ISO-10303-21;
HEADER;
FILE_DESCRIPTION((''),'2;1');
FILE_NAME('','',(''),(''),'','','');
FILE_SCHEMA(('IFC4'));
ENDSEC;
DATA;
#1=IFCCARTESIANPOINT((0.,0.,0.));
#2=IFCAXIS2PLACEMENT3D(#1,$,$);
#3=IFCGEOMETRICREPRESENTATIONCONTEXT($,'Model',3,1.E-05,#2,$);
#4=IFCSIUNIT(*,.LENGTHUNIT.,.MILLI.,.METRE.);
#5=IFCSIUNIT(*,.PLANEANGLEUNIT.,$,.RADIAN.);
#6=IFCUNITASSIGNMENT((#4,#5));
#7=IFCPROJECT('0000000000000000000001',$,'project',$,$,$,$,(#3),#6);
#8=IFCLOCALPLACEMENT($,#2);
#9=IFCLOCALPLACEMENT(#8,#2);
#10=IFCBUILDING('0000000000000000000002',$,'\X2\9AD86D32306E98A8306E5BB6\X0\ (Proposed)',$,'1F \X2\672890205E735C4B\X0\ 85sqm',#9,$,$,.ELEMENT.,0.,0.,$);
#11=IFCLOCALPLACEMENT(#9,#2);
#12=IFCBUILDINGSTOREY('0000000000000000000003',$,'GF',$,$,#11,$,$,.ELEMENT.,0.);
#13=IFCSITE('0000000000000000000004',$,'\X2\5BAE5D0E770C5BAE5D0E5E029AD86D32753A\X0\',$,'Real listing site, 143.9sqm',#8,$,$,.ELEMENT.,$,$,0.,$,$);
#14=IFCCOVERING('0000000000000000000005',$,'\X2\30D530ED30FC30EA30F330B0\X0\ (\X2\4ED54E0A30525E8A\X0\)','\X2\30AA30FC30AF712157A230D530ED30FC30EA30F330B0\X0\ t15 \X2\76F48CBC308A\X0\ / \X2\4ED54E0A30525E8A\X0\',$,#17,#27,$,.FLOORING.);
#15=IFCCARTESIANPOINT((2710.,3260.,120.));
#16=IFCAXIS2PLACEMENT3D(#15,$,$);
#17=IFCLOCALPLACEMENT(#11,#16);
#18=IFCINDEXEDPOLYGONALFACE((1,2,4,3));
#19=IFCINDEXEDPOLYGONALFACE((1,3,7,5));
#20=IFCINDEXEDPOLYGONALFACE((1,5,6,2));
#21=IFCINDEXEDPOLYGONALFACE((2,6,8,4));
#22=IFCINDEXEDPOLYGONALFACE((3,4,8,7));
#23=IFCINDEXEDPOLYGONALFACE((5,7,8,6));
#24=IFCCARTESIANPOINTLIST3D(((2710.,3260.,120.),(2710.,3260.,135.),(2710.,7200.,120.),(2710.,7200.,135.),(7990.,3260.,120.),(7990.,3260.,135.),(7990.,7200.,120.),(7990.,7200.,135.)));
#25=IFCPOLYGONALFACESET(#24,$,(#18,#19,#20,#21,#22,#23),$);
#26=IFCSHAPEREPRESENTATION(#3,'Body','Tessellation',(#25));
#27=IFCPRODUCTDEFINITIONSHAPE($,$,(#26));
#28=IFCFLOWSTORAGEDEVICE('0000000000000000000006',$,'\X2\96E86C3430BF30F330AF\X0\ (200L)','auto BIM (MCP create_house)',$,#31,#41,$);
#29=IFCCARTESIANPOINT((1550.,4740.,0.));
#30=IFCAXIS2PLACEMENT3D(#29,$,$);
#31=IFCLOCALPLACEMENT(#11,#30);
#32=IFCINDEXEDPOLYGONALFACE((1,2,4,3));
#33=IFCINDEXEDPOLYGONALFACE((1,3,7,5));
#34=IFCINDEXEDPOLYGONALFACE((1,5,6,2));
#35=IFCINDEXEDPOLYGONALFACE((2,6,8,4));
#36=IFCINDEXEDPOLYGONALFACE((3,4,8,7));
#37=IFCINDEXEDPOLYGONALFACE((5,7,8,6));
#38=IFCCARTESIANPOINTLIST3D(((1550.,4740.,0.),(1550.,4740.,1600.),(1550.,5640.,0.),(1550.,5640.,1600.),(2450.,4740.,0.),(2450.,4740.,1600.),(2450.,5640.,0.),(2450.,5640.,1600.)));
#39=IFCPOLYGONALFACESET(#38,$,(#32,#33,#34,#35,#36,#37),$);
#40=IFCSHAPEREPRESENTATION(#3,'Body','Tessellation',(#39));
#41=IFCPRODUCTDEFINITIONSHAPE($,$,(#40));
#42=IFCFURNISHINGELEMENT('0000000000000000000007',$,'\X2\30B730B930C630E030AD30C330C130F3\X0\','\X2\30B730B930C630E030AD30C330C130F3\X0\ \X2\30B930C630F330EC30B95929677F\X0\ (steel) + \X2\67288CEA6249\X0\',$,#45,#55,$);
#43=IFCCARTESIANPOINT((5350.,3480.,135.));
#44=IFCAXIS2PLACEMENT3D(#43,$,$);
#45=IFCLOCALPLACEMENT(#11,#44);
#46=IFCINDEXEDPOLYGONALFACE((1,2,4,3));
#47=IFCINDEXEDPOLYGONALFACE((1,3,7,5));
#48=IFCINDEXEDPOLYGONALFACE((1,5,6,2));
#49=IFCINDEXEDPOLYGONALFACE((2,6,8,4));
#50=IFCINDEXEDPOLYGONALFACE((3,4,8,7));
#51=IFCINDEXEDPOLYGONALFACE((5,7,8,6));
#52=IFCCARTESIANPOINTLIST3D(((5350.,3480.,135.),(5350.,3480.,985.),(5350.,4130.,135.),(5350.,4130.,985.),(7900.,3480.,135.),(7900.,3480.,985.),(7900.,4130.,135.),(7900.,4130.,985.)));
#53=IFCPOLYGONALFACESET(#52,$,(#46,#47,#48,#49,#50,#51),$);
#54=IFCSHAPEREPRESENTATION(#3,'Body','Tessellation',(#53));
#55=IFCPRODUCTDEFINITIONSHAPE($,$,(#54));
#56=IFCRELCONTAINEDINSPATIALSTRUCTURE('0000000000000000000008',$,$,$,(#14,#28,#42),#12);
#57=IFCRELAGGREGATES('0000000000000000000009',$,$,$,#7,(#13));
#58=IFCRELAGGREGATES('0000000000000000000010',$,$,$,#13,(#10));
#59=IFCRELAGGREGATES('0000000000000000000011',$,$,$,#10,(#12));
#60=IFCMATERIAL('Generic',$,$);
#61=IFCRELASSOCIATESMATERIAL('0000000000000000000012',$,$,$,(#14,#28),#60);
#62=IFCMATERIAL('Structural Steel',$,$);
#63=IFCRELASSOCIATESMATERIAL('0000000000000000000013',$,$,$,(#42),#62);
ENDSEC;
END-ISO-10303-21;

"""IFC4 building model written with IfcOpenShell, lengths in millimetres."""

from ifc_helpers import new_model, si_unit, frame, frame_2d, origin, place, context, project, spatial, rectangle, extrude, material, element, save


model = new_model("IFC4")

# Units and contexts
model_context = context("Model", 3, precision=1e-05, world=origin())
ifc_project = project(units=[si_unit("LENGTHUNIT", "METRE", prefix="MILLI"), si_unit("PLANEANGLEUNIT", "RADIAN")], contexts=[model_context])

# Site, building, storey
site_placement = place(None, origin())
site = spatial("IfcSite", under=ifc_project, at=site_placement, Name="宮崎県宮崎市高洲町", ObjectType="Real listing site, 143.9sqm", CompositionType="ELEMENT", RefElevation=0.0)
building_placement = place(site_placement, origin())
building = spatial("IfcBuilding", under=site, at=building_placement, Name="高洲の風の家 (Proposed)", ObjectType="1F 木造平屋 85sqm", CompositionType="ELEMENT", ElevationOfRefHeight=0.0, ElevationOfTerrain=0.0)
storey_placement = place(building_placement, origin())
storey = spatial("IfcBuildingStorey", under=building, at=storey_placement, Name="GF", CompositionType="ELEMENT", Elevation=0.0)

# Shared definitions
ifc_material_1 = material(Name="Generic")

# Covering
covering_placement = place(storey_placement, frame((2710.0, 3260.0, 120.0)))
element("IfcCovering", 1, at=covering_placement, inside=storey, material=ifc_material_1, Name="フローリング (仕上げ床)", Description="オーク無垢フローリング t15 直貼り / 仕上げ床", PredefinedType="FLOORING", context=model_context, shape_type="SweptSolid", body=[
    extrude(rectangle(XDim=5280.0, YDim=3940.0, at=frame_2d((2640.0, 1970.0))), frame((2710.0, 3260.0, 120.0)), (0.0, 0.0, 1.0), 15.0),
])

# Flow storage device
flow_storage_device_placement = place(storey_placement, frame((1550.0, 4740.0, 0.0)))
element("IfcFlowStorageDevice", 2, at=flow_storage_device_placement, inside=storey, material=ifc_material_1, Name="雨水タンク (200L)", Description="auto BIM (MCP create_house)", context=model_context, shape_type="SweptSolid", body=[
    extrude(rectangle(XDim=900.0, YDim=900.0, at=frame_2d((450.0, 450.0))), frame((1550.0, 4740.0, 0.0)), (0.0, 0.0, 1.0), 1600.0),
])

# Furnishing element
ifc_material_2 = material(Name="Structural Steel")
furnishing_placement = place(storey_placement, frame((5350.0, 3480.0, 135.0)))
element("IfcFurnishingElement", 3, at=furnishing_placement, inside=storey, material=ifc_material_2, Name="システムキッチン", Description="システムキッチン ステンレス天板 (steel) + 木質扉", context=model_context, shape_type="SweptSolid", body=[
    extrude(rectangle(XDim=2550.0, YDim=650.0, at=frame_2d((1275.0, 325.0))), frame((5350.0, 3480.0, 135.0)), (0.0, 0.0, 1.0), 850.0),
])

save(model, "model.ifc")
